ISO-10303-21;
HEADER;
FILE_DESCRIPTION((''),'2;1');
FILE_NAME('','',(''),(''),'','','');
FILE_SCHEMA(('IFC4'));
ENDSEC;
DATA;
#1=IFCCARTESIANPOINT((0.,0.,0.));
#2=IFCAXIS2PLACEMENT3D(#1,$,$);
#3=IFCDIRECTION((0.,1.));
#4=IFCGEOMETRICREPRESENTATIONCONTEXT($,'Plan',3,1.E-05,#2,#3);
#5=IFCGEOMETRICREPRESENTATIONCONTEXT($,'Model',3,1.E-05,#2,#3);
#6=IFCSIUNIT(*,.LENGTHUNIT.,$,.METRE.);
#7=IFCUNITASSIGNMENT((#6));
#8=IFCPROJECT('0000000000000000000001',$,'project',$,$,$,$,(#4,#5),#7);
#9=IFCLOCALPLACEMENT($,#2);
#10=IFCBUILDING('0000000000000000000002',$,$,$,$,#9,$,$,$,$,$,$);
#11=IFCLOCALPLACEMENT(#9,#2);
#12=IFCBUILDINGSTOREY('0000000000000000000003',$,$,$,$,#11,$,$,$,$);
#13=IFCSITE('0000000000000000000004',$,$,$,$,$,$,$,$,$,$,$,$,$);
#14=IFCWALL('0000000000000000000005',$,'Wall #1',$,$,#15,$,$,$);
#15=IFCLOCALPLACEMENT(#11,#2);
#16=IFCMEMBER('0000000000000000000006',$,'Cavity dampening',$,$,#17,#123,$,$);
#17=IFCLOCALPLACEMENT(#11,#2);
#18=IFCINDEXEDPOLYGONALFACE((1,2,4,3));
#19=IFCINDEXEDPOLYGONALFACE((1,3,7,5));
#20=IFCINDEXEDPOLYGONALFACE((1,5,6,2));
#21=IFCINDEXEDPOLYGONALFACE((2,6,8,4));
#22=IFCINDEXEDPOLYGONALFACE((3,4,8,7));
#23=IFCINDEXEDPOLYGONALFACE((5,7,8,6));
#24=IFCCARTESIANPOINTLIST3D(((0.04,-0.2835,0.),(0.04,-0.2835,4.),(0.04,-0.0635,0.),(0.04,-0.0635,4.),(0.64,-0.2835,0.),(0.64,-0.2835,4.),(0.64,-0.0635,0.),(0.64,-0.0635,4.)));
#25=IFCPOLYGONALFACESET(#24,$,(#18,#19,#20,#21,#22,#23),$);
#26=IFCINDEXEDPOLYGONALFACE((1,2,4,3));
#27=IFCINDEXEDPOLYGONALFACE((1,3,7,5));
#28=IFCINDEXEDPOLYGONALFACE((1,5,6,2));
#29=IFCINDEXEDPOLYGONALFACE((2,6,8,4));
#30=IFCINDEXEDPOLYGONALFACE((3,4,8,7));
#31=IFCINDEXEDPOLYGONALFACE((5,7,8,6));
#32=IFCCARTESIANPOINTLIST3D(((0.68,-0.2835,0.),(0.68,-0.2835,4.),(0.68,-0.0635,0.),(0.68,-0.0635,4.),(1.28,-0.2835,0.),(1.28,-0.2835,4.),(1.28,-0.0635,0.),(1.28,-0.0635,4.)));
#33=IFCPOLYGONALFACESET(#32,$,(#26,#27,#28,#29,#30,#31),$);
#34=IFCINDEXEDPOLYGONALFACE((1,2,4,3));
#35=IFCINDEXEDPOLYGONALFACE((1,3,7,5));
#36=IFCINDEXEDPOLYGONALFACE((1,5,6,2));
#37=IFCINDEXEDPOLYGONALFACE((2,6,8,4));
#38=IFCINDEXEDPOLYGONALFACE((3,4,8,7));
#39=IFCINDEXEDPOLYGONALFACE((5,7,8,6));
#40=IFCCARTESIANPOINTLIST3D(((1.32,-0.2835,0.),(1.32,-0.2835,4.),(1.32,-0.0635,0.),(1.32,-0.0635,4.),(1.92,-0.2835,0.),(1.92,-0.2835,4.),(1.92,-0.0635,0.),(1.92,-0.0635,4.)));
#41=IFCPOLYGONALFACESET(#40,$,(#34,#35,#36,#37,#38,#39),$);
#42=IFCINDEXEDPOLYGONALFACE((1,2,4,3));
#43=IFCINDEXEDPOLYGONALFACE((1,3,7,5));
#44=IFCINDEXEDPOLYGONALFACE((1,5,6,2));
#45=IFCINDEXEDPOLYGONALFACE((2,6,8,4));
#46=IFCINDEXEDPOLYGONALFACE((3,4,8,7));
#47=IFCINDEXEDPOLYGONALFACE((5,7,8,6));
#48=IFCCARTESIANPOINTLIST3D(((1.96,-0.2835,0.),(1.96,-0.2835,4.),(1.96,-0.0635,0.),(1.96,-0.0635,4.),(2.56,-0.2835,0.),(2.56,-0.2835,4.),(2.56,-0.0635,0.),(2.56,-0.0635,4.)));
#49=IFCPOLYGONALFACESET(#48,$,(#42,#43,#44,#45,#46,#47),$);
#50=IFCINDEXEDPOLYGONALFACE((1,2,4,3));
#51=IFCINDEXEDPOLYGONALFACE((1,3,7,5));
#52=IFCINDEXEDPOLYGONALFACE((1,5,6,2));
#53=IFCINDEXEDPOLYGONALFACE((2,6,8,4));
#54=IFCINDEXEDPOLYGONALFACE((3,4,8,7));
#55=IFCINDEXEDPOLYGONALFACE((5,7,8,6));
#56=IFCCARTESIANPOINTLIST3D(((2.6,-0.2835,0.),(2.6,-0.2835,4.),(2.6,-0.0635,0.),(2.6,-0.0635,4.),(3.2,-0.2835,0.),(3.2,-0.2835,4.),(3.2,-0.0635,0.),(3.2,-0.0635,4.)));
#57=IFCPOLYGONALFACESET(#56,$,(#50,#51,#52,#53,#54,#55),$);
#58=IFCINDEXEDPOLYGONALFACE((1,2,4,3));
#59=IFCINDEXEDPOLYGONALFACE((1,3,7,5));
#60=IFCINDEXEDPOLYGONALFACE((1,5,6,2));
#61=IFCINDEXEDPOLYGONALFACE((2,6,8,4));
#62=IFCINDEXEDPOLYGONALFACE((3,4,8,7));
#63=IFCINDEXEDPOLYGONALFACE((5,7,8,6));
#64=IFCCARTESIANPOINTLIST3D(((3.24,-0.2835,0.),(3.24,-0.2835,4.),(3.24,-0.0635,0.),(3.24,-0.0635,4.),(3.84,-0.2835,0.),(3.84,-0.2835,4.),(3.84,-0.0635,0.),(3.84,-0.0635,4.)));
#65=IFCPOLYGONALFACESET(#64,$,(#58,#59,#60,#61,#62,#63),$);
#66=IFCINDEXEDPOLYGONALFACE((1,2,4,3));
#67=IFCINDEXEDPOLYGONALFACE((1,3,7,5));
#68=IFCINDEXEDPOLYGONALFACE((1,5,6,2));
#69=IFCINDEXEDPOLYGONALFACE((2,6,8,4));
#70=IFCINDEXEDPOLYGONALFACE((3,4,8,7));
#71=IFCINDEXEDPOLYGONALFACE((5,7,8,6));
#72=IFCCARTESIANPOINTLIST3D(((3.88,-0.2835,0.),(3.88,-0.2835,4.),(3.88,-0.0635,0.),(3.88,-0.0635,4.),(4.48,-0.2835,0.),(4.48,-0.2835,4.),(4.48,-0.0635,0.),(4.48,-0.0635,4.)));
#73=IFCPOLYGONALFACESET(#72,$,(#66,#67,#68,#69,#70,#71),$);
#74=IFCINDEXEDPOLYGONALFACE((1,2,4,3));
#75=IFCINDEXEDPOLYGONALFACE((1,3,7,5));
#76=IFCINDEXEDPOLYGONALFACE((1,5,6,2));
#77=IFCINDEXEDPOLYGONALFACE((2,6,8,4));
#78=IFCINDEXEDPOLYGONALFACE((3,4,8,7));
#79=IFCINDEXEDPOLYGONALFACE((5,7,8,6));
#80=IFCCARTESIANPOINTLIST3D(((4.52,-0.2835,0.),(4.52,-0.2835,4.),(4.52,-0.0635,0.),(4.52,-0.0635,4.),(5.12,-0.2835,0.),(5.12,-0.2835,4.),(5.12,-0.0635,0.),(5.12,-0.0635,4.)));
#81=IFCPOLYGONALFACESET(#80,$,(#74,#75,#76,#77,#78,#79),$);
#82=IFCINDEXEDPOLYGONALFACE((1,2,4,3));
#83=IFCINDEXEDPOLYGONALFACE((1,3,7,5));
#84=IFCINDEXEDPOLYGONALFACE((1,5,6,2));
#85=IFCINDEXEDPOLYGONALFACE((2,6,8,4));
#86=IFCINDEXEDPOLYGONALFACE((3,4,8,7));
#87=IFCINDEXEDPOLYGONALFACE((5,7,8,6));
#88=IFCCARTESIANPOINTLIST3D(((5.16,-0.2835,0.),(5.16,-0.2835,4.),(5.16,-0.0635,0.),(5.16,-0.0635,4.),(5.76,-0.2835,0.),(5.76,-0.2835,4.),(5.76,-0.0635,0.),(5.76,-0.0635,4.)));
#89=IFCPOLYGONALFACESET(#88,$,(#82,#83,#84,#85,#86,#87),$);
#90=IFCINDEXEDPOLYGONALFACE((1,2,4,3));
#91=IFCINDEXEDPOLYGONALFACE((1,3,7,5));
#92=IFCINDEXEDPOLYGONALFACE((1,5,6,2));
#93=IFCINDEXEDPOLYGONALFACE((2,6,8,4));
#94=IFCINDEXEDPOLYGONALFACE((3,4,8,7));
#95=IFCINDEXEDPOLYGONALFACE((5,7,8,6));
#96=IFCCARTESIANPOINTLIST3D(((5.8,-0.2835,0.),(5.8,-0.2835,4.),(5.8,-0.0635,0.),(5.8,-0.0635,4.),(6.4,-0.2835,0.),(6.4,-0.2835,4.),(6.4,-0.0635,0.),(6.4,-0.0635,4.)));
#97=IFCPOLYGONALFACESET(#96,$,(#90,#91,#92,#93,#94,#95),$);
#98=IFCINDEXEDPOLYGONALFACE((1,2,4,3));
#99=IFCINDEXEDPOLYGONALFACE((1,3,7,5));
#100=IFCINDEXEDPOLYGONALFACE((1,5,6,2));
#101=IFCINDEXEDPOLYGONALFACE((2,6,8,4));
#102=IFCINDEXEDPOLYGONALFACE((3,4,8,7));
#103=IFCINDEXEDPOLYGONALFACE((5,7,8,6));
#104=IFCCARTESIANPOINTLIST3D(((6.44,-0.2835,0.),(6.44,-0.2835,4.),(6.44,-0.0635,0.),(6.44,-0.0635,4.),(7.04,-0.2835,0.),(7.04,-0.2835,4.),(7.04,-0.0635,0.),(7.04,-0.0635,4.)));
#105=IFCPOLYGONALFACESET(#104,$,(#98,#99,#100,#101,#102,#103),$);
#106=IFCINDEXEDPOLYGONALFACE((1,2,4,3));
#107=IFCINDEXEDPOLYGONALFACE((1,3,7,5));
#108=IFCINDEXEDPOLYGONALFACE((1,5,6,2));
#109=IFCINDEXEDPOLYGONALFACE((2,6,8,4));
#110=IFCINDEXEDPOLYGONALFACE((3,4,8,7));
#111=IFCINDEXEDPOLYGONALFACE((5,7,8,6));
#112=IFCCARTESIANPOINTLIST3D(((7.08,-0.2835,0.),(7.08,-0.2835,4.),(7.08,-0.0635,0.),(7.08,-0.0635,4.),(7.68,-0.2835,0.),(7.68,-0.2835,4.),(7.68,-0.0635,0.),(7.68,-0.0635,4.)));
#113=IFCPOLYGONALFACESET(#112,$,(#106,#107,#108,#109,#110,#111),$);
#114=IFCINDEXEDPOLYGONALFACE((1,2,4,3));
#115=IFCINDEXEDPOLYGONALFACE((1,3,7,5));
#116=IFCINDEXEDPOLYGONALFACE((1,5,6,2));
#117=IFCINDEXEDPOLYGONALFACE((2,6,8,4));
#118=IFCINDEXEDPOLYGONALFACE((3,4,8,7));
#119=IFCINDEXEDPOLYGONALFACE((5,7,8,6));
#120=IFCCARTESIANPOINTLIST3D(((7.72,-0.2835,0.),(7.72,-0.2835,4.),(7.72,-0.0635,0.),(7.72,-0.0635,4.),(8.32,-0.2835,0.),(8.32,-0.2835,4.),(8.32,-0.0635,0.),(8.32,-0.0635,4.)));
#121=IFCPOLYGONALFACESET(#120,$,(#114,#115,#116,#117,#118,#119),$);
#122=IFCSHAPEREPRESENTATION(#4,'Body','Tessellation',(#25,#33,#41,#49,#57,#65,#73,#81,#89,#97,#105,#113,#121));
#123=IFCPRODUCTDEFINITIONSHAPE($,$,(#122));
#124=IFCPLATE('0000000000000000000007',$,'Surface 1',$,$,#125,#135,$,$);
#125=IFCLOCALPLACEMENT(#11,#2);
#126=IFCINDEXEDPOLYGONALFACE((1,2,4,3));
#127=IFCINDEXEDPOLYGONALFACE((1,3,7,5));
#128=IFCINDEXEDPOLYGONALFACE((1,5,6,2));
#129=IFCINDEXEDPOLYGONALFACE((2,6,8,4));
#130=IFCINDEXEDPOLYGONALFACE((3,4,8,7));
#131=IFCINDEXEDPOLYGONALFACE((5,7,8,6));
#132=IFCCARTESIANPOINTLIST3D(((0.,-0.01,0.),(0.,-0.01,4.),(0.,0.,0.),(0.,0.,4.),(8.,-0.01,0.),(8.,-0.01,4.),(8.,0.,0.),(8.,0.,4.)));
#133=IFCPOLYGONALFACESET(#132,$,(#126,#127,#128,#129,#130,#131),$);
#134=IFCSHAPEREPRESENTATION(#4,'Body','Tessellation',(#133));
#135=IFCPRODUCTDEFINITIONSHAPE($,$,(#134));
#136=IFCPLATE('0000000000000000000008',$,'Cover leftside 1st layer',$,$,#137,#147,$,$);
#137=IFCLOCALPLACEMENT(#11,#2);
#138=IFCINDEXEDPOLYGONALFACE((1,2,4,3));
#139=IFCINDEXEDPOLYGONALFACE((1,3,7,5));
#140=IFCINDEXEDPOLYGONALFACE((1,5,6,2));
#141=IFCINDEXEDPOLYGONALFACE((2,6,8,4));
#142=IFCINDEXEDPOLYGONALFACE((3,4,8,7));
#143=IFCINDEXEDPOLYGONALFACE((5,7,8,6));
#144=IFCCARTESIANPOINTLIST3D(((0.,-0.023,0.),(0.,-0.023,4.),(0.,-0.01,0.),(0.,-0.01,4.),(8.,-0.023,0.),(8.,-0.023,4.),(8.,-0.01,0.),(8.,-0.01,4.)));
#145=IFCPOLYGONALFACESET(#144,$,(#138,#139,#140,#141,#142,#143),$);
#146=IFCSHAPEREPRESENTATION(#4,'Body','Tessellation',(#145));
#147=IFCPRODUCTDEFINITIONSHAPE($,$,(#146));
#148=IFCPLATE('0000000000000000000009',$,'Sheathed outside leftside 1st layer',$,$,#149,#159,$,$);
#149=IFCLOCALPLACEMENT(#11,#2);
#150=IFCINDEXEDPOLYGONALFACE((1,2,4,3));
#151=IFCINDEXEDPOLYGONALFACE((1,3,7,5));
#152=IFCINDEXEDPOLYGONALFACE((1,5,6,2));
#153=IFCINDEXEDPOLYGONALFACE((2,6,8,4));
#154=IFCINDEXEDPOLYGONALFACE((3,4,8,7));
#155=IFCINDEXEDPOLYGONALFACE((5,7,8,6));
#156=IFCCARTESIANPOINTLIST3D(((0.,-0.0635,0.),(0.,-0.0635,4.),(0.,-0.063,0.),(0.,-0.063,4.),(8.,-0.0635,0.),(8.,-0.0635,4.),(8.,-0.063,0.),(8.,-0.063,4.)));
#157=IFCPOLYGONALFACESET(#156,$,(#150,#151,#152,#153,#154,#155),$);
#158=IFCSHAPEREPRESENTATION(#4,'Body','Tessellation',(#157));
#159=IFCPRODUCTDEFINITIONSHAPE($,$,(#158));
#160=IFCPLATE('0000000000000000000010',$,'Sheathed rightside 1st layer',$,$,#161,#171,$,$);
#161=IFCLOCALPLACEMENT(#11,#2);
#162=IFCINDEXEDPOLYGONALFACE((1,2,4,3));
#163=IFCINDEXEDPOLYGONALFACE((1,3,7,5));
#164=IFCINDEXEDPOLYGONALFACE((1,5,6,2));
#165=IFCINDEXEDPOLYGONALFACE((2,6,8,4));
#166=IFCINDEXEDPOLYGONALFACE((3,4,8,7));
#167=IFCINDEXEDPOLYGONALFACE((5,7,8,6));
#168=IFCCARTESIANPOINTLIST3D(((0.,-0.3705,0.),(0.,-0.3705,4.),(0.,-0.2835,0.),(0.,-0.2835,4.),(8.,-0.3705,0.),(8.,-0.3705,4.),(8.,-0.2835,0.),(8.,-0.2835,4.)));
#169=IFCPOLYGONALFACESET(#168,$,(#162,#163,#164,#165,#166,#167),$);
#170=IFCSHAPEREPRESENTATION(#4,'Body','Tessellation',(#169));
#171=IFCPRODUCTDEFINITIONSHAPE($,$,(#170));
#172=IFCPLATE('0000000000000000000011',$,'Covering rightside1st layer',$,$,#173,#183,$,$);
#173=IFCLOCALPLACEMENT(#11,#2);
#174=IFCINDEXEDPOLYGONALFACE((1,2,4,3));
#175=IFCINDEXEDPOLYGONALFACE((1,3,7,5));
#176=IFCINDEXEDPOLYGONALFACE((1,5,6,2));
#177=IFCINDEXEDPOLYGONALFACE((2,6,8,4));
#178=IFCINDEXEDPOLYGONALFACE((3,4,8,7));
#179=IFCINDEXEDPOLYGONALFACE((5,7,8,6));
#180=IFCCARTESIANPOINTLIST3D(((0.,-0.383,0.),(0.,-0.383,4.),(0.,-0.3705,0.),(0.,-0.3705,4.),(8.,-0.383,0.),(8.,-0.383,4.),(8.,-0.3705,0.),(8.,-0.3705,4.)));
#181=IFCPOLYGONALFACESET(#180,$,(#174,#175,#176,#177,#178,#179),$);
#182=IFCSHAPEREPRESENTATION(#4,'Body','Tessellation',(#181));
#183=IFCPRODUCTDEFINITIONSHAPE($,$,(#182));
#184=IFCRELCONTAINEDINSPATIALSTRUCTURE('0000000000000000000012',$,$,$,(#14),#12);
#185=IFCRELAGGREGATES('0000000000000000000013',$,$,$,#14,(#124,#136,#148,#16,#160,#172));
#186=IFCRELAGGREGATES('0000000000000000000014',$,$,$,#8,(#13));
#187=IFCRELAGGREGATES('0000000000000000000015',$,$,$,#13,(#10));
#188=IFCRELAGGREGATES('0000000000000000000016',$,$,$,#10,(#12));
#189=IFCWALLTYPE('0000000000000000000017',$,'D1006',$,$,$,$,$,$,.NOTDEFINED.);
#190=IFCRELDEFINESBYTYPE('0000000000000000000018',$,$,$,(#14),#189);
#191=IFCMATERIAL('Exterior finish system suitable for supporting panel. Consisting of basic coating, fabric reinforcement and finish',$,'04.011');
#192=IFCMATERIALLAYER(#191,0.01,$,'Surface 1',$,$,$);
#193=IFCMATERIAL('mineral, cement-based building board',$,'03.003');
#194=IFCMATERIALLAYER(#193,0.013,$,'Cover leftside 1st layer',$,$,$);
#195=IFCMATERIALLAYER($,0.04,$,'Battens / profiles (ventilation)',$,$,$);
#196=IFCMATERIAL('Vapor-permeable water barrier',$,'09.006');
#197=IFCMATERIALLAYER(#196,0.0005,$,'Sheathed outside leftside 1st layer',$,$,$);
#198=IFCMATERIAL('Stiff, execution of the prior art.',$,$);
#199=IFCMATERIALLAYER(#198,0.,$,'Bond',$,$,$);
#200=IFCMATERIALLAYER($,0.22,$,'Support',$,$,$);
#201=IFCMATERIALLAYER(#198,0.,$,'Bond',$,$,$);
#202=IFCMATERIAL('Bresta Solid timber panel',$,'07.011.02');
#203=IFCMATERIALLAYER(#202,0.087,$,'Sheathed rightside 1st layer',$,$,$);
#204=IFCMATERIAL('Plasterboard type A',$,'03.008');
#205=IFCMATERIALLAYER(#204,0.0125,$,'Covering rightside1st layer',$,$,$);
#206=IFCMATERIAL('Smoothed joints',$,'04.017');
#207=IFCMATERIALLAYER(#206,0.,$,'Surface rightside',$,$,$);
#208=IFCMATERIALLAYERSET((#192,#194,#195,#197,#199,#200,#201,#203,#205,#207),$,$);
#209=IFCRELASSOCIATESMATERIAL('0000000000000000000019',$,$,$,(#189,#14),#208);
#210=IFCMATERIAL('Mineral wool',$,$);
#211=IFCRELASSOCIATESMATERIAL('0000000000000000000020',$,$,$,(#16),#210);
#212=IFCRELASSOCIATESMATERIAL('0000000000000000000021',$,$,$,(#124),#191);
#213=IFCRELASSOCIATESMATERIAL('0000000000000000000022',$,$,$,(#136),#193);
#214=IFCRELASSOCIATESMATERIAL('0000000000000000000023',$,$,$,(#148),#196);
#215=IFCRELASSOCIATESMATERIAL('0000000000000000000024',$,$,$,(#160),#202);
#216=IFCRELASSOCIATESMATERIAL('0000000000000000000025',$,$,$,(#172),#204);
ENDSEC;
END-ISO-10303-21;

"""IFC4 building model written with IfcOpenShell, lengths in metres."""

from ifc_helpers import new_model, si_unit, direction, frame, frame_2d, origin, origin_with_axes, place, context, project, spatial, rectangle, extrude, material, layer, layer_set, type_object, element, aggregate, save


model = new_model("IFC4")

# Units and contexts
plan_context = context("Plan", 3, precision=1e-05, world=origin(), true_north=direction((0.0, 1.0)))
model_context = context("Model", 3, precision=1e-05, world=origin(), true_north=direction((0.0, 1.0)))
ifc_project = project(units=[si_unit("LENGTHUNIT", "METRE")], contexts=[plan_context, model_context])

# Site, building, storey
site = spatial("IfcSite", under=ifc_project)
building_placement = place(None, origin())
building = spatial("IfcBuilding", under=site, at=building_placement)
storey_placement = place(building_placement, origin())
storey = spatial("IfcBuildingStorey", under=building, at=storey_placement)

# Wall, member, plates
ifc_material_1 = material(Name="Exterior finish system suitable for supporting panel. Consisting of basic coating, fabric reinforcement and finish", Category="04.011")
ifc_layer_1 = layer(ifc_material_1, 0.01, Name="Surface 1")
ifc_material_2 = material(Name="mineral, cement-based building board", Category="03.003")
ifc_layer_2 = layer(ifc_material_2, 0.013, Name="Cover leftside 1st layer")
ifc_layer_3 = layer(None, 0.04, Name="Battens / profiles (ventilation)")
ifc_material_3 = material(Name="Vapor-permeable water barrier", Category="09.006")
ifc_layer_4 = layer(ifc_material_3, 0.0005, Name="Sheathed outside leftside 1st layer")
ifc_material_4 = material(Name="Stiff, execution of the prior art.")
ifc_layer_5 = layer(ifc_material_4, 0.0, Name="Bond")
ifc_layer_6 = layer(None, 0.22, Name="Support")
ifc_layer_7 = layer(ifc_material_4, 0.0, Name="Bond")
ifc_material_5 = material(Name="Bresta Solid timber panel", Category="07.011.02")
ifc_layer_8 = layer(ifc_material_5, 0.087, Name="Sheathed rightside 1st layer")
ifc_material_6 = material(Name="Plasterboard type A", Category="03.008")
ifc_layer_9 = layer(ifc_material_6, 0.0125, Name="Covering rightside1st layer")
ifc_material_7 = material(Name="Smoothed joints", Category="04.017")
ifc_layer_10 = layer(ifc_material_7, 0.0, Name="Surface rightside")
ifc_layer_set = layer_set([ifc_layer_1, ifc_layer_2, ifc_layer_3, ifc_layer_4, ifc_layer_5, ifc_layer_6, ifc_layer_7, ifc_layer_8, ifc_layer_9, ifc_layer_10])
wall_type = type_object("IfcWallType", Name="D1006", PredefinedType="NOTDEFINED", material=ifc_layer_set)
wall_placement = place(None, frame((0.0, 0.0, 0.0), z_axis=(0.0, -1.0, 0.0), x_axis=(1.0, 0.0, 0.0)))
wall = element("IfcWall", 1, at=wall_placement, inside=storey, type_object=wall_type, material=ifc_layer_set, Name="Wall #1")
ifc_material_8 = material(Name="Mineral wool")
member_1_placement = place(wall_placement, origin())
member_1 = element("IfcMember", 2, at=member_1_placement, material=ifc_material_8, Name="Cavity dampening", context=plan_context, shape_type="SweptSolid", body=[
    extrude(rectangle(XDim=0.6, YDim=0.22, at=frame_2d((0.3, 0.11), x_axis=(1.0, 0.0))), frame((0.04, 4.0, 0.0635), z_axis=(0.0, -1.0, 0.0), x_axis=(1.0, 0.0, 0.0)), (0.0, 0.0, 1.0), 4.0),
    extrude(rectangle(XDim=0.6, YDim=0.22, at=frame_2d((0.3, 0.11), x_axis=(1.0, 0.0))), frame((0.68, 4.0, 0.0635), z_axis=(0.0, -1.0, 0.0), x_axis=(1.0, 0.0, 0.0)), (0.0, 0.0, 1.0), 4.0),
    extrude(rectangle(XDim=0.6, YDim=0.22, at=frame_2d((0.3, 0.11), x_axis=(1.0, 0.0))), frame((1.32, 4.0, 0.0635), z_axis=(0.0, -1.0, 0.0), x_axis=(1.0, 0.0, 0.0)), (0.0, 0.0, 1.0), 4.0),
    extrude(rectangle(XDim=0.6, YDim=0.22, at=frame_2d((0.3, 0.11), x_axis=(1.0, 0.0))), frame((1.96, 4.0, 0.0635), z_axis=(0.0, -1.0, 0.0), x_axis=(1.0, 0.0, 0.0)), (0.0, 0.0, 1.0), 4.0),
    extrude(rectangle(XDim=0.6, YDim=0.22, at=frame_2d((0.3, 0.11), x_axis=(1.0, 0.0))), frame((2.6, 4.0, 0.0635), z_axis=(0.0, -1.0, 0.0), x_axis=(1.0, 0.0, 0.0)), (0.0, 0.0, 1.0), 4.0),
    extrude(rectangle(XDim=0.6, YDim=0.22, at=frame_2d((0.3, 0.11), x_axis=(1.0, 0.0))), frame((3.24, 4.0, 0.0635), z_axis=(0.0, -1.0, 0.0), x_axis=(1.0, 0.0, 0.0)), (0.0, 0.0, 1.0), 4.0),
    extrude(rectangle(XDim=0.6, YDim=0.22, at=frame_2d((0.3, 0.11), x_axis=(1.0, 0.0))), frame((3.88, 4.0, 0.0635), z_axis=(0.0, -1.0, 0.0), x_axis=(1.0, 0.0, 0.0)), (0.0, 0.0, 1.0), 4.0),
    extrude(rectangle(XDim=0.6, YDim=0.22, at=frame_2d((0.3, 0.11), x_axis=(1.0, 0.0))), frame((4.52, 4.0, 0.0635), z_axis=(0.0, -1.0, 0.0), x_axis=(1.0, 0.0, 0.0)), (0.0, 0.0, 1.0), 4.0),
    extrude(rectangle(XDim=0.6, YDim=0.22, at=frame_2d((0.3, 0.11), x_axis=(1.0, 0.0))), frame((5.16, 4.0, 0.0635), z_axis=(0.0, -1.0, 0.0), x_axis=(1.0, 0.0, 0.0)), (0.0, 0.0, 1.0), 4.0),
    extrude(rectangle(XDim=0.6, YDim=0.22, at=frame_2d((0.3, 0.11), x_axis=(1.0, 0.0))), frame((5.8, 4.0, 0.0635), z_axis=(0.0, -1.0, 0.0), x_axis=(1.0, 0.0, 0.0)), (0.0, 0.0, 1.0), 4.0),
    extrude(rectangle(XDim=0.6, YDim=0.22, at=frame_2d((0.3, 0.11), x_axis=(1.0, 0.0))), frame((6.44, 4.0, 0.0635), z_axis=(0.0, -1.0, 0.0), x_axis=(1.0, 0.0, 0.0)), (0.0, 0.0, 1.0), 4.0),
    extrude(rectangle(XDim=0.6, YDim=0.22, at=frame_2d((0.3, 0.11), x_axis=(1.0, 0.0))), frame((7.08, 4.0, 0.0635), z_axis=(0.0, -1.0, 0.0), x_axis=(1.0, 0.0, 0.0)), (0.0, 0.0, 1.0), 4.0),
    extrude(rectangle(XDim=0.6, YDim=0.22, at=frame_2d((0.3, 0.11), x_axis=(1.0, 0.0))), frame((7.72, 4.0, 0.0635), z_axis=(0.0, -1.0, 0.0), x_axis=(1.0, 0.0, 0.0)), (0.0, 0.0, 1.0), 4.0),
])
plate_1_placement = place(wall_placement, origin())
plate_1 = element("IfcPlate", 3, at=plate_1_placement, material=ifc_material_1, Name="Surface 1", context=plan_context, shape_type="SweptSolid", body=[
    extrude(rectangle(XDim=8.0, YDim=4.0, at=frame_2d((4.0, 2.0), x_axis=(1.0, 0.0))), origin_with_axes(), (0.0, 0.0, 1.0), 0.01),
])
plate_2_placement = place(wall_placement, origin())
plate_2 = element("IfcPlate", 4, at=plate_2_placement, material=ifc_material_2, Name="Cover leftside 1st layer", context=plan_context, shape_type="SweptSolid", body=[
    extrude(rectangle(XDim=8.0, YDim=4.0, at=frame_2d((4.0, 2.0), x_axis=(1.0, 0.0))), frame((0.0, 0.0, 0.01), z_axis=(0.0, 0.0, 1.0), x_axis=(1.0, 0.0, 0.0)), (0.0, 0.0, 1.0), 0.013),
])
plate_3_placement = place(wall_placement, origin())
plate_3 = element("IfcPlate", 5, at=plate_3_placement, material=ifc_material_3, Name="Sheathed outside leftside 1st layer", context=plan_context, shape_type="SweptSolid", body=[
    extrude(rectangle(XDim=8.0, YDim=4.0, at=frame_2d((4.0, 2.0), x_axis=(1.0, 0.0))), frame((0.0, 0.0, 0.063), z_axis=(0.0, 0.0, 1.0), x_axis=(1.0, 0.0, 0.0)), (0.0, 0.0, 1.0), 0.0005),
])
plate_4_placement = place(wall_placement, origin())
plate_4 = element("IfcPlate", 6, at=plate_4_placement, material=ifc_material_5, Name="Sheathed rightside 1st layer", context=plan_context, shape_type="SweptSolid", body=[
    extrude(rectangle(XDim=8.0, YDim=4.0, at=frame_2d((4.0, 2.0), x_axis=(1.0, 0.0))), frame((0.0, 0.0, 0.2835), z_axis=(0.0, 0.0, 1.0), x_axis=(1.0, 0.0, 0.0)), (0.0, 0.0, 1.0), 0.087),
])
plate_5_placement = place(wall_placement, origin())
plate_5 = element("IfcPlate", 7, at=plate_5_placement, material=ifc_material_6, Name="Covering rightside1st layer", context=plan_context, shape_type="SweptSolid", body=[
    extrude(rectangle(XDim=8.0, YDim=4.0, at=frame_2d((4.0, 2.0), x_axis=(1.0, 0.0))), frame((0.0, 0.0, 0.3705), z_axis=(0.0, 0.0, 1.0), x_axis=(1.0, 0.0, 0.0)), (0.0, 0.0, 1.0), 0.0125),
])
aggregate(wall, [plate_1, plate_2, plate_3, member_1, plate_4, plate_5])

save(model, "model.ifc")
